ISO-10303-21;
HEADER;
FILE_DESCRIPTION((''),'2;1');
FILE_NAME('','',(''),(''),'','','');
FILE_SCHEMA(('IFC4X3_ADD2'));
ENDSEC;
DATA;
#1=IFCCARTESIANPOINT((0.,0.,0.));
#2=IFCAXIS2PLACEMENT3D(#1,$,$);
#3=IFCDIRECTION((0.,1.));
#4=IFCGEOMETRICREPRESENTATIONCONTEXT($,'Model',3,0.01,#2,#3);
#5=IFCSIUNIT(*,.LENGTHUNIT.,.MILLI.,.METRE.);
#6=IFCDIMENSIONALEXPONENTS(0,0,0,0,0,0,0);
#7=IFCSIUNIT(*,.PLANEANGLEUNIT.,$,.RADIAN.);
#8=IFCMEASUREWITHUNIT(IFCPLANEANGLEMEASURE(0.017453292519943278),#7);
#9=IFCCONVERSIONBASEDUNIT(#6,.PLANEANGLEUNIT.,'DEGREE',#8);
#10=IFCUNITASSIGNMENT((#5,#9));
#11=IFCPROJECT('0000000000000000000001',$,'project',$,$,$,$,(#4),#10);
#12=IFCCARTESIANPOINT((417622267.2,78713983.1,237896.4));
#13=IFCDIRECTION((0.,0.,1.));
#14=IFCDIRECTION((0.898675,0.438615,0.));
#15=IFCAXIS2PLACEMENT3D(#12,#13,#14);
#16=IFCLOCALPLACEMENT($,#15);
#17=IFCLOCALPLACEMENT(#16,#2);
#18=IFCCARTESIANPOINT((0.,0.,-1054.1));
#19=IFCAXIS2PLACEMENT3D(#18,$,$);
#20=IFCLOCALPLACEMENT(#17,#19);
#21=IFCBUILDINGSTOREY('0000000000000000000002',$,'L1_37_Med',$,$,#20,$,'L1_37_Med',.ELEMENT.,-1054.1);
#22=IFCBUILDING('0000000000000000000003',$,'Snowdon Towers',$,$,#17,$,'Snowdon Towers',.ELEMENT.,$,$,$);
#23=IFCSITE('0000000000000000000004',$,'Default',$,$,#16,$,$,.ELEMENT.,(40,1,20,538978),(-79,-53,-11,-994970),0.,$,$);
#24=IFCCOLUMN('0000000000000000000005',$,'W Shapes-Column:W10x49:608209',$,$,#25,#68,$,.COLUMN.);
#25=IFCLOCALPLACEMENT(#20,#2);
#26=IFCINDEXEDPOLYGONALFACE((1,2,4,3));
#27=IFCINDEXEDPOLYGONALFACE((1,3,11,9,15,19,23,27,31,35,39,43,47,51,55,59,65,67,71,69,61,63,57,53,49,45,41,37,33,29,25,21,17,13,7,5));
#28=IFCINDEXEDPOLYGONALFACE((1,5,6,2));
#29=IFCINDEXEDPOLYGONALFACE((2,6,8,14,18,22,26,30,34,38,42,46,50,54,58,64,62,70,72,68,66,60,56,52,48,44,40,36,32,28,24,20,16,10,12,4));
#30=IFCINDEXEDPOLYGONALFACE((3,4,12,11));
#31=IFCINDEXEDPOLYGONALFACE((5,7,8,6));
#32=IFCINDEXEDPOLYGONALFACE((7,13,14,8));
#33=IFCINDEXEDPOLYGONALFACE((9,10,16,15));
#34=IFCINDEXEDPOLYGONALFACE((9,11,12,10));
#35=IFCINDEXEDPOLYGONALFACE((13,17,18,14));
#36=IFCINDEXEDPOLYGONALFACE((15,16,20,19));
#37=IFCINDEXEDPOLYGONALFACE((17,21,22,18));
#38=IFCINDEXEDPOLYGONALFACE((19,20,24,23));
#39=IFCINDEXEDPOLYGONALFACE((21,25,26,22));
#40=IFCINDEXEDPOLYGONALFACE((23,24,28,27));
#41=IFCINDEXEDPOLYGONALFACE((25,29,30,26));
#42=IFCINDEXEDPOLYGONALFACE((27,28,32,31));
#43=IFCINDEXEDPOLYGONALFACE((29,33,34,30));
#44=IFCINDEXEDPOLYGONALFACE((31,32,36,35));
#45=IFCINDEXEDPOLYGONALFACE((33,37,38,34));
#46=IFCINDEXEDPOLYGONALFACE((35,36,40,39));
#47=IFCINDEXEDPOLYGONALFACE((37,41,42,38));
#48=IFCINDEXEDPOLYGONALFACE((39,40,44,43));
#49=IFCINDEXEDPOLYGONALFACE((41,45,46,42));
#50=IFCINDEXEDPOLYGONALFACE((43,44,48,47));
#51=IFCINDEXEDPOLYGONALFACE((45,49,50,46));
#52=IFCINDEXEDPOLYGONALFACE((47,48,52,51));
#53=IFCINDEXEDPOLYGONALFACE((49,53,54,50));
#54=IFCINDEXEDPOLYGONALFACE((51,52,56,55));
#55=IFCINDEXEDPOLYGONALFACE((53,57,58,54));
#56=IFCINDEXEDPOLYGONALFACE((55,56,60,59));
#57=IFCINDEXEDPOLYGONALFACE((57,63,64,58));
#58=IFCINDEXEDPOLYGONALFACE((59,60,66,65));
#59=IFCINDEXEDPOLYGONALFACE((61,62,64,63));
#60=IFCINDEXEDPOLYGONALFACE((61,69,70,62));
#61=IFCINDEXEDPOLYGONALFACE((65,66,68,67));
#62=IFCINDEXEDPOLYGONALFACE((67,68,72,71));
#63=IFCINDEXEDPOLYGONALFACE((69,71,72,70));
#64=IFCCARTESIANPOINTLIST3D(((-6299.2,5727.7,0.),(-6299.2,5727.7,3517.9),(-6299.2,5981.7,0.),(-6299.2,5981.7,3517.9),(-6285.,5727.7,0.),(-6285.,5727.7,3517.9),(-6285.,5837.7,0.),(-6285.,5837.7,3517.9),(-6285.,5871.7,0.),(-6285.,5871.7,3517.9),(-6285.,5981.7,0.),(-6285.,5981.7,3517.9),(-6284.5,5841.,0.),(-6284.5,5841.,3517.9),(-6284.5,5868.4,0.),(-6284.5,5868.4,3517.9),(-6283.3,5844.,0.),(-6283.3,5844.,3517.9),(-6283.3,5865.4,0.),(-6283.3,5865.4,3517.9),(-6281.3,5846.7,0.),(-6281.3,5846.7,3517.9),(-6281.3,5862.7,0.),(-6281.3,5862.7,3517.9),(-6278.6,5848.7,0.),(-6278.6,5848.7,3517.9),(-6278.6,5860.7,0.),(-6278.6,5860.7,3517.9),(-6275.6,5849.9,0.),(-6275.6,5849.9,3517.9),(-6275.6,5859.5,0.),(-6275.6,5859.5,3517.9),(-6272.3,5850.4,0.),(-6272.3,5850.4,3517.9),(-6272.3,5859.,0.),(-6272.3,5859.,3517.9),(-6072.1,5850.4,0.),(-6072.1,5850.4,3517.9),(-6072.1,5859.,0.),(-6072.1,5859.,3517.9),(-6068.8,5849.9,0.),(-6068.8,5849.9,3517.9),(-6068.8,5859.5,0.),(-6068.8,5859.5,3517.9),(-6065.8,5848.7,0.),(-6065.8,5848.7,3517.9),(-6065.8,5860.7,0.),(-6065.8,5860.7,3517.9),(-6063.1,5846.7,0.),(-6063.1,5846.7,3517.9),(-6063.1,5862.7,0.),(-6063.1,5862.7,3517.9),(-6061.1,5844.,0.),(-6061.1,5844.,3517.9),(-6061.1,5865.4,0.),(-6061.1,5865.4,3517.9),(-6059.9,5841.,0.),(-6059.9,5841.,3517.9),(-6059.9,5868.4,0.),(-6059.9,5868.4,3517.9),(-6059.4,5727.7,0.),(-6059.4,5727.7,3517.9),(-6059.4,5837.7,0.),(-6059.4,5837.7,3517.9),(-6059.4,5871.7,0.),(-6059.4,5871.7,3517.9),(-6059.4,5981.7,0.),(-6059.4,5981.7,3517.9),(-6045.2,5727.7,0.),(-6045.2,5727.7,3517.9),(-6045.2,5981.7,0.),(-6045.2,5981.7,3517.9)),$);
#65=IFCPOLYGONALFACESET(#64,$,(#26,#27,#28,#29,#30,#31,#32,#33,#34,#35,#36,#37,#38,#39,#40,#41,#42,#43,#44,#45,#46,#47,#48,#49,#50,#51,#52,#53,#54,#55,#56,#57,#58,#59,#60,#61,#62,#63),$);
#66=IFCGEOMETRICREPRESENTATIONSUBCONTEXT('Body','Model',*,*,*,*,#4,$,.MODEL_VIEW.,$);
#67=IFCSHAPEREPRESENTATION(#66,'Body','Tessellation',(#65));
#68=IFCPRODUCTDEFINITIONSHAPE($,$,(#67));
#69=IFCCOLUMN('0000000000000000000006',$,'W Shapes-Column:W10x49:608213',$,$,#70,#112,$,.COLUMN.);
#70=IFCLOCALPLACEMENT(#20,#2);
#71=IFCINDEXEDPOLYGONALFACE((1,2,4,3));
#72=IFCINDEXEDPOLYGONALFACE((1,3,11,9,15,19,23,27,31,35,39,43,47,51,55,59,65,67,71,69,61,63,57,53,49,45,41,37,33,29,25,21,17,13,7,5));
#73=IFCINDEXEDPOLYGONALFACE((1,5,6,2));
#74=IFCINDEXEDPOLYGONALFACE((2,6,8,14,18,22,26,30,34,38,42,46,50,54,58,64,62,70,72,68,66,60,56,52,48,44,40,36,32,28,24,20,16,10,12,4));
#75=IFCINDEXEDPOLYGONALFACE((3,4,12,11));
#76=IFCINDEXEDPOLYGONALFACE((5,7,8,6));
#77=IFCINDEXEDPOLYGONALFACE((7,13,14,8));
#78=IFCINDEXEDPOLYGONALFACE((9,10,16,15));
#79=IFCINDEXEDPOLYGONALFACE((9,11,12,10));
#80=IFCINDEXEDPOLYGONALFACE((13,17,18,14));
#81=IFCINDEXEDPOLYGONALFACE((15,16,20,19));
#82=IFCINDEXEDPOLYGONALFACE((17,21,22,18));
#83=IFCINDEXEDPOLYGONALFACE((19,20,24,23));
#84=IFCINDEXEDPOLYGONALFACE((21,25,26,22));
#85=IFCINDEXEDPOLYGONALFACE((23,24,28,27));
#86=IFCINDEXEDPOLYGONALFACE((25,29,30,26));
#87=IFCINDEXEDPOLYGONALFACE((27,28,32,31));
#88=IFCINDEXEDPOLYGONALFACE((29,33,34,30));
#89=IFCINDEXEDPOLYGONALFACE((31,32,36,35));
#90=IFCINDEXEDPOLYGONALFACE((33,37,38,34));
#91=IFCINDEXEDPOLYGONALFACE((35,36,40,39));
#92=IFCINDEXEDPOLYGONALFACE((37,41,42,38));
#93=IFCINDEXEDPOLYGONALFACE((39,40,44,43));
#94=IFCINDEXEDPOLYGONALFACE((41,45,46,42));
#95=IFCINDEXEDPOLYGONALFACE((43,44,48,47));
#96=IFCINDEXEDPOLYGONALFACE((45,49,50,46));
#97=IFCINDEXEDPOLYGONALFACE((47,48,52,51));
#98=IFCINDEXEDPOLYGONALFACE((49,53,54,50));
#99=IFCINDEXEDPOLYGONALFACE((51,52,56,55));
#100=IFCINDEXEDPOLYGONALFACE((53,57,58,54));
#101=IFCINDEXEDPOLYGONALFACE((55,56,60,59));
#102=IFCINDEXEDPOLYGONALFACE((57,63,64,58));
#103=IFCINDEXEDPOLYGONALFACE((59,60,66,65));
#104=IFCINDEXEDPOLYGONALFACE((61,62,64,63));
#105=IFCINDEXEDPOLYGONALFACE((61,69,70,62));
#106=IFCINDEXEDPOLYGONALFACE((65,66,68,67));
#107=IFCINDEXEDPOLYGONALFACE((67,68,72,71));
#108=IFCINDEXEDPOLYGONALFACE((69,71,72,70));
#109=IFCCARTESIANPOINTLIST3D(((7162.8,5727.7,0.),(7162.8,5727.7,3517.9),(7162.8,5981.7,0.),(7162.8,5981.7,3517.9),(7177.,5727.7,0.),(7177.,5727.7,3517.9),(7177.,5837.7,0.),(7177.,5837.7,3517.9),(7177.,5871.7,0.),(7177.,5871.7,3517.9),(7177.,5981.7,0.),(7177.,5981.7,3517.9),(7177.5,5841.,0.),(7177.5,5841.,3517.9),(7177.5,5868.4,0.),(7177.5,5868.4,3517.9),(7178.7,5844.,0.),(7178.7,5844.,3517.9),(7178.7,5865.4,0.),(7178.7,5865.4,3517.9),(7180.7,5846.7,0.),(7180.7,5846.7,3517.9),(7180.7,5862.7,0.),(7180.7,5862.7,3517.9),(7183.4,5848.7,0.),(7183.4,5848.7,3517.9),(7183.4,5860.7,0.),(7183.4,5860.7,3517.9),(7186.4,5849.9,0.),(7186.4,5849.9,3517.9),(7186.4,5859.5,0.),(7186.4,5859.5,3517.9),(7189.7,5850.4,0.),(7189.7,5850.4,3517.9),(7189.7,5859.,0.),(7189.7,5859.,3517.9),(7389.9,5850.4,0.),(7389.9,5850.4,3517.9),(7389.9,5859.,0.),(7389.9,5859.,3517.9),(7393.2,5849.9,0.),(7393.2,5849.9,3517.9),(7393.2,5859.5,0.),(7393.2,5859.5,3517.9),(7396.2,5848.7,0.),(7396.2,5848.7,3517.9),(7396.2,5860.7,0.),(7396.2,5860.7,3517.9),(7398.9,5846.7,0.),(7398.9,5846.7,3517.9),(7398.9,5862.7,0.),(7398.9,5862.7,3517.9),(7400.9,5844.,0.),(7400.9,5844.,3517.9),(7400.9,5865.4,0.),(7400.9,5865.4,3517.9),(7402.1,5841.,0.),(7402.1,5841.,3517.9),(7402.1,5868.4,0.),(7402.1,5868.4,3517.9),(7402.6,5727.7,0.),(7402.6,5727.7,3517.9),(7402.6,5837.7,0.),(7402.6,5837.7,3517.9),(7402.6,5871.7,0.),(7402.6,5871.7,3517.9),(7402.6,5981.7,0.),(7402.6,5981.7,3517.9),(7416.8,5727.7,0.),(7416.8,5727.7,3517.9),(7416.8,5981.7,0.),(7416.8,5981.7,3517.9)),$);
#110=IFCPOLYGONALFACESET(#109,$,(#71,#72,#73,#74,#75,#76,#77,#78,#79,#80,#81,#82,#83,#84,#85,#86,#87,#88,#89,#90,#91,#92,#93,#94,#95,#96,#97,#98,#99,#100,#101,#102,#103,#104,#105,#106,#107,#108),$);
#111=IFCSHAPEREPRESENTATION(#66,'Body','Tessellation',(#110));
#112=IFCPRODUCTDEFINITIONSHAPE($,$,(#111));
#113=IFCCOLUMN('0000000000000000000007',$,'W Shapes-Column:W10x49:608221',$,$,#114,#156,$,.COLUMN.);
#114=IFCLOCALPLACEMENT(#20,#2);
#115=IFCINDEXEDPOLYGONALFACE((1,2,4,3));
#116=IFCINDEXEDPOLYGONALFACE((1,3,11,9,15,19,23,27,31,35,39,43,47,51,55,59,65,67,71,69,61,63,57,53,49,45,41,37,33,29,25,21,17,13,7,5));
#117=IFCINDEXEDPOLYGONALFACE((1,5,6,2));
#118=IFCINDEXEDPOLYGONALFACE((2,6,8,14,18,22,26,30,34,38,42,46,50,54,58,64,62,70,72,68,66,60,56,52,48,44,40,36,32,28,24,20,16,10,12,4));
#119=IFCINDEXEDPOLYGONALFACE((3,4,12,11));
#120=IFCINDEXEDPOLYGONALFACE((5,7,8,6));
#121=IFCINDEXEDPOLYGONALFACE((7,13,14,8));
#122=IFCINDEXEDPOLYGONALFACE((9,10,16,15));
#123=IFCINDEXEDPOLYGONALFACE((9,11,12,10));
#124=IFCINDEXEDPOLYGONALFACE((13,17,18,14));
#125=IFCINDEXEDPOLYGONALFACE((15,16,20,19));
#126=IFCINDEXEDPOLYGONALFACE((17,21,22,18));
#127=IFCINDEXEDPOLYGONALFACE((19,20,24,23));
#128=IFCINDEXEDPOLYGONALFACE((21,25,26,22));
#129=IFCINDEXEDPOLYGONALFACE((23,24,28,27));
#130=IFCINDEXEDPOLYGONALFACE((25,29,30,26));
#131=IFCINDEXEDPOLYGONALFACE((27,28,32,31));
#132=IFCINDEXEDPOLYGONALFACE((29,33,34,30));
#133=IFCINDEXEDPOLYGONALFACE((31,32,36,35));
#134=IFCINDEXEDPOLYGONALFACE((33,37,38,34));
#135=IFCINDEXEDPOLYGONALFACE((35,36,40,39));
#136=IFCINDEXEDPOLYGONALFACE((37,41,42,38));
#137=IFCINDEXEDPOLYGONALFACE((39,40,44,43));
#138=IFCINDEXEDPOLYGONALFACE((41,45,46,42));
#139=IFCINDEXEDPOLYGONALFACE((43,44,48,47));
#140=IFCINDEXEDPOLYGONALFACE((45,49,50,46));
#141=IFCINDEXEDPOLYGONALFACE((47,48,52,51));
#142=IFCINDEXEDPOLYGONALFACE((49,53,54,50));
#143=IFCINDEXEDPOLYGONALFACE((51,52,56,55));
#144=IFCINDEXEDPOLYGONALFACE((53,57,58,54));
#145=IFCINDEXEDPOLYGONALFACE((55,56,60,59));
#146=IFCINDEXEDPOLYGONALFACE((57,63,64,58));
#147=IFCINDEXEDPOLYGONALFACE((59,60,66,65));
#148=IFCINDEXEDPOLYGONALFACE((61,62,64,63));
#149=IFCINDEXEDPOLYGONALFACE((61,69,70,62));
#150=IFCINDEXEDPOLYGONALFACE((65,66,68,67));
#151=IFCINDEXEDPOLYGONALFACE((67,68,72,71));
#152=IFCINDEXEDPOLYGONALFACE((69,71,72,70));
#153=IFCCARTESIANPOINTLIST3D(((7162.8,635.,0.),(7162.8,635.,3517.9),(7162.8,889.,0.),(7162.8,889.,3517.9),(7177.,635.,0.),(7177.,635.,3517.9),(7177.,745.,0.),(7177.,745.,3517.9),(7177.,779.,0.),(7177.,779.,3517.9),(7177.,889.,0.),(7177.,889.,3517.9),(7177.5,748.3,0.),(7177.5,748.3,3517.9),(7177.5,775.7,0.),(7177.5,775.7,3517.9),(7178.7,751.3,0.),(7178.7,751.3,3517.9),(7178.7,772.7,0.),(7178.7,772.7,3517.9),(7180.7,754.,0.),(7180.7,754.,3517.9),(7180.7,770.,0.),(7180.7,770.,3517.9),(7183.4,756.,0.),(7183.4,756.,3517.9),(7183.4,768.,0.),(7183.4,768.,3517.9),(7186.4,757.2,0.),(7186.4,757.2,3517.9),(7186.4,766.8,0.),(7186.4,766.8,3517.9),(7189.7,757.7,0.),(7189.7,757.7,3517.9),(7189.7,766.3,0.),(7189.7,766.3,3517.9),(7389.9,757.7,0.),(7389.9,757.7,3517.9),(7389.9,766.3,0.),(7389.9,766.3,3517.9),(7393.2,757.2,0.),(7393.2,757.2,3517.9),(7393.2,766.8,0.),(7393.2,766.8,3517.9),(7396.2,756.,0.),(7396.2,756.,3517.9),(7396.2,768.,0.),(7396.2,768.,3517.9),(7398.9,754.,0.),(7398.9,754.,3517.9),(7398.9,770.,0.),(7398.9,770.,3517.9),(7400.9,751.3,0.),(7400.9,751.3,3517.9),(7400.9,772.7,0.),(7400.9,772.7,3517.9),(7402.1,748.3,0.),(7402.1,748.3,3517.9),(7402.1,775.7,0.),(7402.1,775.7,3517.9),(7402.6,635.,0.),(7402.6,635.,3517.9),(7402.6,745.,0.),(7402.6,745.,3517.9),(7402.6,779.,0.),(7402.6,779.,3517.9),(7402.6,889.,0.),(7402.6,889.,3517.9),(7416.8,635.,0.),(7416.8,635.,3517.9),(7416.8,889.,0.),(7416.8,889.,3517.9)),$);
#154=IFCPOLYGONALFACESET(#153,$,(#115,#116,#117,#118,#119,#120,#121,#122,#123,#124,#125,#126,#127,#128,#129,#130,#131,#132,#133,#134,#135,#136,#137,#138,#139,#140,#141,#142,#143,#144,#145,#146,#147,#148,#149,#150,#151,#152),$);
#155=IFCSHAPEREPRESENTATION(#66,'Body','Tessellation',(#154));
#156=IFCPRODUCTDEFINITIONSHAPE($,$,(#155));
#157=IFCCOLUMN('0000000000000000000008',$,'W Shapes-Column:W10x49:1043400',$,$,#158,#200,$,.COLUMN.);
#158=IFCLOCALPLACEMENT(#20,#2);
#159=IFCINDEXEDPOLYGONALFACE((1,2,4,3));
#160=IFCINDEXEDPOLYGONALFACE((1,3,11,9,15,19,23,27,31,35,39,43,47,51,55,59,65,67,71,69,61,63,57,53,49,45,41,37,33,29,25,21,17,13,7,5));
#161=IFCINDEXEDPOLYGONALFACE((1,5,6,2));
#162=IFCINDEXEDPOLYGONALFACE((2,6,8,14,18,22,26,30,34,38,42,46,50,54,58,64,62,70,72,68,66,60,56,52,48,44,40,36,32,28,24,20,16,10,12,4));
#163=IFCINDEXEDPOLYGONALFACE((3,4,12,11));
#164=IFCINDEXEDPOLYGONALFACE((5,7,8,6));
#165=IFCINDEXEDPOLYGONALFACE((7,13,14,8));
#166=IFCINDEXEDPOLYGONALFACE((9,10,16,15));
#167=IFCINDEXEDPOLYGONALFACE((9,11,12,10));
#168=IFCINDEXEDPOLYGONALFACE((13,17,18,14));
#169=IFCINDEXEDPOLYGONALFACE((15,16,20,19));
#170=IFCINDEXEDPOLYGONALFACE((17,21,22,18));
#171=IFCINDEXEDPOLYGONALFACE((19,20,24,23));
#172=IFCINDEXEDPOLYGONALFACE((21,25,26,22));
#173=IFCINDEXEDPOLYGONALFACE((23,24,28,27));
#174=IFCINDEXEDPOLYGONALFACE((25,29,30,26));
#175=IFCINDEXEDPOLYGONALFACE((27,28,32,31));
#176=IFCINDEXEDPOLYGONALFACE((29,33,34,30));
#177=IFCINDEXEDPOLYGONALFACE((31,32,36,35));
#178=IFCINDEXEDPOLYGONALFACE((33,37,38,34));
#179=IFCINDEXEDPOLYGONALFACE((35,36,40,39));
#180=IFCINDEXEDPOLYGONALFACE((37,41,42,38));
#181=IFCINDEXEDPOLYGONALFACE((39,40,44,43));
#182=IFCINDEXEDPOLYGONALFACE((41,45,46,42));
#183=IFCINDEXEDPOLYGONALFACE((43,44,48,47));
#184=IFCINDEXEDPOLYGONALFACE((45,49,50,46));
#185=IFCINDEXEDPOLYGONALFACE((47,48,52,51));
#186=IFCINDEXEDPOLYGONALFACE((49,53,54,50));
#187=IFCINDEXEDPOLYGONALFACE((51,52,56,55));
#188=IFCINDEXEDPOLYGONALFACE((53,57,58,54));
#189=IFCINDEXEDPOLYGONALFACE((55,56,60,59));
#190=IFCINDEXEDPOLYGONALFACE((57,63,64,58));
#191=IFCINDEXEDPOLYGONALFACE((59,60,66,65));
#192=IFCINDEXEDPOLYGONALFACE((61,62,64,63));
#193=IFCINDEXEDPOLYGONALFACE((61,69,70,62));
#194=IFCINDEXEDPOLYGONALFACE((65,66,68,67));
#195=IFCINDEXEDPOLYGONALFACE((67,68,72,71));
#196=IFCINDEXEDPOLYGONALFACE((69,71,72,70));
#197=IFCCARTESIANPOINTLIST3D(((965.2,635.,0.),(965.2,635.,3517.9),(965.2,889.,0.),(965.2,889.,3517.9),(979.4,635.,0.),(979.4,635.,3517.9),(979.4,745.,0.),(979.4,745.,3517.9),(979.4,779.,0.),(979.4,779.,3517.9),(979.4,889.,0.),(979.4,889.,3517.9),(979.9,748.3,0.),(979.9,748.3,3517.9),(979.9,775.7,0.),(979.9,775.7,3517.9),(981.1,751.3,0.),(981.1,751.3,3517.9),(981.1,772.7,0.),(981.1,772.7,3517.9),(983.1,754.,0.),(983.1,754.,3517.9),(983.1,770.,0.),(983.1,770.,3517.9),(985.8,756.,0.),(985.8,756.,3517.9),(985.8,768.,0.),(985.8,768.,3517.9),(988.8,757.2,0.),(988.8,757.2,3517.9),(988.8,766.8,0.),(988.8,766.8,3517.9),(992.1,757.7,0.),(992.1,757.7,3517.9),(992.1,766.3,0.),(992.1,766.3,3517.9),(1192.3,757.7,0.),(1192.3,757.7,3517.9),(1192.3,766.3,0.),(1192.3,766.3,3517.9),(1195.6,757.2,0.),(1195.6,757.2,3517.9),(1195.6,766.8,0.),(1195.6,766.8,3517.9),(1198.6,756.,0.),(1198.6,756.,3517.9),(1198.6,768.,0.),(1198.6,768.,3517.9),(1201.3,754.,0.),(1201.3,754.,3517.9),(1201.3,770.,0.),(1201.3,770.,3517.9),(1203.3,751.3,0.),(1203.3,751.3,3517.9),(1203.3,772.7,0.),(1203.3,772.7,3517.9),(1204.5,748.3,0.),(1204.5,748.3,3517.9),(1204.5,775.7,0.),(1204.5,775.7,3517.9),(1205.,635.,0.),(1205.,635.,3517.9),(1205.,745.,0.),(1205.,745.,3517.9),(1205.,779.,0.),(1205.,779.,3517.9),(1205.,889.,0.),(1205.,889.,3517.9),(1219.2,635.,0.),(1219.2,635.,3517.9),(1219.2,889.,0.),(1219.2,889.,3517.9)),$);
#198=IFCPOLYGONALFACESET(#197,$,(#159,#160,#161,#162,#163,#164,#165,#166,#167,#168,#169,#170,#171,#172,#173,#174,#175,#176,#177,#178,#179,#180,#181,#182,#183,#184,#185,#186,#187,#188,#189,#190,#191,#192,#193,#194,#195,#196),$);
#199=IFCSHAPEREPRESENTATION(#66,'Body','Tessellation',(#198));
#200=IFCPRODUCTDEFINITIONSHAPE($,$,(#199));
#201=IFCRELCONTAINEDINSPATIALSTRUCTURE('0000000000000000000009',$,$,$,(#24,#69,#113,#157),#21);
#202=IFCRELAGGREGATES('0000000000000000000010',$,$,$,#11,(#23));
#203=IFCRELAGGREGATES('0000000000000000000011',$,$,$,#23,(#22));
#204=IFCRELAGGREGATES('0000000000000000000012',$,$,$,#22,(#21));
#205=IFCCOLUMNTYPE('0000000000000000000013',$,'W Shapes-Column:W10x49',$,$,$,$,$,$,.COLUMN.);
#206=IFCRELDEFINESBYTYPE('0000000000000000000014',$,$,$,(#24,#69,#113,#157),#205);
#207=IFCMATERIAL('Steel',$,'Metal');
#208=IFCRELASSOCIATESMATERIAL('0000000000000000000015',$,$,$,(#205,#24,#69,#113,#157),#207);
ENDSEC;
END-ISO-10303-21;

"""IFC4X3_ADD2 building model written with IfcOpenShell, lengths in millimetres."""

from ifc_helpers import new_model, entity, si_unit, converted_unit, direction, frame, frame_2d, origin, place, context, subcontext, project, spatial, i_section, extrude, source, transform, mapped, material, material_profile, profile_set, profile_usage, type_object, type_shapes, element, save


model = new_model("IFC4X3_ADD2")

# Units and contexts
model_context = context("Model", 3, precision=0.01, world=origin(), true_north=direction((0.0, 1.0)))
body_context = subcontext(model_context, "Body", "Model", "MODEL_VIEW")
ifc_project = project(units=[si_unit("LENGTHUNIT", "METRE", prefix="MILLI"), converted_unit("PLANEANGLEUNIT", "DEGREE", entity("IfcPlaneAngleMeasure", 0.017453292519943278), si_unit("PLANEANGLEUNIT", "RADIAN"), dimensions=[0, 0, 0, 0, 0, 0, 0])], contexts=[model_context])

# Site, building, storey
site_placement = place(None, frame((417622267.2, 78713983.1, 237896.4), z_axis=(0.0, 0.0, 1.0), x_axis=(0.898675, 0.438615, 0.0)))
site = spatial("IfcSite", under=ifc_project, at=site_placement, Name="Default", CompositionType="ELEMENT", RefLatitude=(40, 1, 20, 538978), RefLongitude=(-79, -53, -11, -994970), RefElevation=0.0)
building_placement = place(site_placement, origin())
building = spatial("IfcBuilding", under=site, at=building_placement, Name="Snowdon Towers", LongName="Snowdon Towers", CompositionType="ELEMENT")
storey_placement = place(building_placement, frame((0.0, 0.0, -1054.1)))
storey = spatial("IfcBuildingStorey", under=building, at=storey_placement, Name="L1_37_Med", LongName="L1_37_Med", CompositionType="ELEMENT", Elevation=-1054.1)

# Columns
ifc_material_1 = material(Name="Steel", Category="Metal")
ifc_material_profile_1 = material_profile(ifc_material_1, i_section(OverallWidth=254.0, OverallDepth=254.0, WebThickness=8.6, FlangeThickness=14.2, FilletRadius=12.7, at=frame_2d((0.0, 0.0), x_axis=(1.0, 0.0))), Name="W10x49")
ifc_profile_set_1 = profile_set([ifc_material_profile_1], Name="W10x49")
ifc_profile_usage_1 = profile_usage(ifc_profile_set_1)
column_type_1 = type_object("IfcColumnType", Name="W Shapes-Column:W10x49", PredefinedType="COLUMN", material=ifc_profile_set_1)
shared_shape_1 = source(origin(), body_context, "Body", "SweptSolid", [
    extrude(i_section(OverallWidth=254.0, OverallDepth=254.0, WebThickness=8.6, FlangeThickness=14.2, FilletRadius=12.7, at=frame_2d((0.0, 0.0), x_axis=(1.0, 0.0))), frame((0.0, 0.0, -1054.1), z_axis=(0.0, 0.0, 1.0), x_axis=(-1.0, 0.0, 0.0)), (0.0, 0.0, 1.0), 3517.9),
])
type_shapes(column_type_1, [shared_shape_1])
for number, where, z_axis, x_axis, name in (
    (1, (-6172.2, 5854.7, 1054.1), (0.0, 0.0, 1.0), (0.0, 1.0, 0.0), "W Shapes-Column:W10x49:608209"),
    (2, (7289.8, 5854.7, 1054.1), (0.0, 0.0, 1.0), (0.0, 1.0, 0.0), "W Shapes-Column:W10x49:608213"),
    (3, (7289.8, 762.0, 1054.1), (0.0, 0.0, 1.0), (0.0, 1.0, 0.0), "W Shapes-Column:W10x49:608221"),
    (4, (1092.2, 762.0, 1054.1), (0.0, 0.0, 1.0), (0.0, 1.0, 0.0), "W Shapes-Column:W10x49:1043400"),
):
    element("IfcColumn", number, at=place(storey_placement, frame(where, z_axis=z_axis, x_axis=x_axis)), inside=storey, type_object=column_type_1, material=ifc_profile_usage_1, Name=name, PredefinedType="COLUMN", context=body_context, shape_type="MappedRepresentation", body=[
        mapped(shared_shape_1, transform((0.0, 0.0, 0.0), scale=1.0)),
    ])

save(model, "model.ifc")
